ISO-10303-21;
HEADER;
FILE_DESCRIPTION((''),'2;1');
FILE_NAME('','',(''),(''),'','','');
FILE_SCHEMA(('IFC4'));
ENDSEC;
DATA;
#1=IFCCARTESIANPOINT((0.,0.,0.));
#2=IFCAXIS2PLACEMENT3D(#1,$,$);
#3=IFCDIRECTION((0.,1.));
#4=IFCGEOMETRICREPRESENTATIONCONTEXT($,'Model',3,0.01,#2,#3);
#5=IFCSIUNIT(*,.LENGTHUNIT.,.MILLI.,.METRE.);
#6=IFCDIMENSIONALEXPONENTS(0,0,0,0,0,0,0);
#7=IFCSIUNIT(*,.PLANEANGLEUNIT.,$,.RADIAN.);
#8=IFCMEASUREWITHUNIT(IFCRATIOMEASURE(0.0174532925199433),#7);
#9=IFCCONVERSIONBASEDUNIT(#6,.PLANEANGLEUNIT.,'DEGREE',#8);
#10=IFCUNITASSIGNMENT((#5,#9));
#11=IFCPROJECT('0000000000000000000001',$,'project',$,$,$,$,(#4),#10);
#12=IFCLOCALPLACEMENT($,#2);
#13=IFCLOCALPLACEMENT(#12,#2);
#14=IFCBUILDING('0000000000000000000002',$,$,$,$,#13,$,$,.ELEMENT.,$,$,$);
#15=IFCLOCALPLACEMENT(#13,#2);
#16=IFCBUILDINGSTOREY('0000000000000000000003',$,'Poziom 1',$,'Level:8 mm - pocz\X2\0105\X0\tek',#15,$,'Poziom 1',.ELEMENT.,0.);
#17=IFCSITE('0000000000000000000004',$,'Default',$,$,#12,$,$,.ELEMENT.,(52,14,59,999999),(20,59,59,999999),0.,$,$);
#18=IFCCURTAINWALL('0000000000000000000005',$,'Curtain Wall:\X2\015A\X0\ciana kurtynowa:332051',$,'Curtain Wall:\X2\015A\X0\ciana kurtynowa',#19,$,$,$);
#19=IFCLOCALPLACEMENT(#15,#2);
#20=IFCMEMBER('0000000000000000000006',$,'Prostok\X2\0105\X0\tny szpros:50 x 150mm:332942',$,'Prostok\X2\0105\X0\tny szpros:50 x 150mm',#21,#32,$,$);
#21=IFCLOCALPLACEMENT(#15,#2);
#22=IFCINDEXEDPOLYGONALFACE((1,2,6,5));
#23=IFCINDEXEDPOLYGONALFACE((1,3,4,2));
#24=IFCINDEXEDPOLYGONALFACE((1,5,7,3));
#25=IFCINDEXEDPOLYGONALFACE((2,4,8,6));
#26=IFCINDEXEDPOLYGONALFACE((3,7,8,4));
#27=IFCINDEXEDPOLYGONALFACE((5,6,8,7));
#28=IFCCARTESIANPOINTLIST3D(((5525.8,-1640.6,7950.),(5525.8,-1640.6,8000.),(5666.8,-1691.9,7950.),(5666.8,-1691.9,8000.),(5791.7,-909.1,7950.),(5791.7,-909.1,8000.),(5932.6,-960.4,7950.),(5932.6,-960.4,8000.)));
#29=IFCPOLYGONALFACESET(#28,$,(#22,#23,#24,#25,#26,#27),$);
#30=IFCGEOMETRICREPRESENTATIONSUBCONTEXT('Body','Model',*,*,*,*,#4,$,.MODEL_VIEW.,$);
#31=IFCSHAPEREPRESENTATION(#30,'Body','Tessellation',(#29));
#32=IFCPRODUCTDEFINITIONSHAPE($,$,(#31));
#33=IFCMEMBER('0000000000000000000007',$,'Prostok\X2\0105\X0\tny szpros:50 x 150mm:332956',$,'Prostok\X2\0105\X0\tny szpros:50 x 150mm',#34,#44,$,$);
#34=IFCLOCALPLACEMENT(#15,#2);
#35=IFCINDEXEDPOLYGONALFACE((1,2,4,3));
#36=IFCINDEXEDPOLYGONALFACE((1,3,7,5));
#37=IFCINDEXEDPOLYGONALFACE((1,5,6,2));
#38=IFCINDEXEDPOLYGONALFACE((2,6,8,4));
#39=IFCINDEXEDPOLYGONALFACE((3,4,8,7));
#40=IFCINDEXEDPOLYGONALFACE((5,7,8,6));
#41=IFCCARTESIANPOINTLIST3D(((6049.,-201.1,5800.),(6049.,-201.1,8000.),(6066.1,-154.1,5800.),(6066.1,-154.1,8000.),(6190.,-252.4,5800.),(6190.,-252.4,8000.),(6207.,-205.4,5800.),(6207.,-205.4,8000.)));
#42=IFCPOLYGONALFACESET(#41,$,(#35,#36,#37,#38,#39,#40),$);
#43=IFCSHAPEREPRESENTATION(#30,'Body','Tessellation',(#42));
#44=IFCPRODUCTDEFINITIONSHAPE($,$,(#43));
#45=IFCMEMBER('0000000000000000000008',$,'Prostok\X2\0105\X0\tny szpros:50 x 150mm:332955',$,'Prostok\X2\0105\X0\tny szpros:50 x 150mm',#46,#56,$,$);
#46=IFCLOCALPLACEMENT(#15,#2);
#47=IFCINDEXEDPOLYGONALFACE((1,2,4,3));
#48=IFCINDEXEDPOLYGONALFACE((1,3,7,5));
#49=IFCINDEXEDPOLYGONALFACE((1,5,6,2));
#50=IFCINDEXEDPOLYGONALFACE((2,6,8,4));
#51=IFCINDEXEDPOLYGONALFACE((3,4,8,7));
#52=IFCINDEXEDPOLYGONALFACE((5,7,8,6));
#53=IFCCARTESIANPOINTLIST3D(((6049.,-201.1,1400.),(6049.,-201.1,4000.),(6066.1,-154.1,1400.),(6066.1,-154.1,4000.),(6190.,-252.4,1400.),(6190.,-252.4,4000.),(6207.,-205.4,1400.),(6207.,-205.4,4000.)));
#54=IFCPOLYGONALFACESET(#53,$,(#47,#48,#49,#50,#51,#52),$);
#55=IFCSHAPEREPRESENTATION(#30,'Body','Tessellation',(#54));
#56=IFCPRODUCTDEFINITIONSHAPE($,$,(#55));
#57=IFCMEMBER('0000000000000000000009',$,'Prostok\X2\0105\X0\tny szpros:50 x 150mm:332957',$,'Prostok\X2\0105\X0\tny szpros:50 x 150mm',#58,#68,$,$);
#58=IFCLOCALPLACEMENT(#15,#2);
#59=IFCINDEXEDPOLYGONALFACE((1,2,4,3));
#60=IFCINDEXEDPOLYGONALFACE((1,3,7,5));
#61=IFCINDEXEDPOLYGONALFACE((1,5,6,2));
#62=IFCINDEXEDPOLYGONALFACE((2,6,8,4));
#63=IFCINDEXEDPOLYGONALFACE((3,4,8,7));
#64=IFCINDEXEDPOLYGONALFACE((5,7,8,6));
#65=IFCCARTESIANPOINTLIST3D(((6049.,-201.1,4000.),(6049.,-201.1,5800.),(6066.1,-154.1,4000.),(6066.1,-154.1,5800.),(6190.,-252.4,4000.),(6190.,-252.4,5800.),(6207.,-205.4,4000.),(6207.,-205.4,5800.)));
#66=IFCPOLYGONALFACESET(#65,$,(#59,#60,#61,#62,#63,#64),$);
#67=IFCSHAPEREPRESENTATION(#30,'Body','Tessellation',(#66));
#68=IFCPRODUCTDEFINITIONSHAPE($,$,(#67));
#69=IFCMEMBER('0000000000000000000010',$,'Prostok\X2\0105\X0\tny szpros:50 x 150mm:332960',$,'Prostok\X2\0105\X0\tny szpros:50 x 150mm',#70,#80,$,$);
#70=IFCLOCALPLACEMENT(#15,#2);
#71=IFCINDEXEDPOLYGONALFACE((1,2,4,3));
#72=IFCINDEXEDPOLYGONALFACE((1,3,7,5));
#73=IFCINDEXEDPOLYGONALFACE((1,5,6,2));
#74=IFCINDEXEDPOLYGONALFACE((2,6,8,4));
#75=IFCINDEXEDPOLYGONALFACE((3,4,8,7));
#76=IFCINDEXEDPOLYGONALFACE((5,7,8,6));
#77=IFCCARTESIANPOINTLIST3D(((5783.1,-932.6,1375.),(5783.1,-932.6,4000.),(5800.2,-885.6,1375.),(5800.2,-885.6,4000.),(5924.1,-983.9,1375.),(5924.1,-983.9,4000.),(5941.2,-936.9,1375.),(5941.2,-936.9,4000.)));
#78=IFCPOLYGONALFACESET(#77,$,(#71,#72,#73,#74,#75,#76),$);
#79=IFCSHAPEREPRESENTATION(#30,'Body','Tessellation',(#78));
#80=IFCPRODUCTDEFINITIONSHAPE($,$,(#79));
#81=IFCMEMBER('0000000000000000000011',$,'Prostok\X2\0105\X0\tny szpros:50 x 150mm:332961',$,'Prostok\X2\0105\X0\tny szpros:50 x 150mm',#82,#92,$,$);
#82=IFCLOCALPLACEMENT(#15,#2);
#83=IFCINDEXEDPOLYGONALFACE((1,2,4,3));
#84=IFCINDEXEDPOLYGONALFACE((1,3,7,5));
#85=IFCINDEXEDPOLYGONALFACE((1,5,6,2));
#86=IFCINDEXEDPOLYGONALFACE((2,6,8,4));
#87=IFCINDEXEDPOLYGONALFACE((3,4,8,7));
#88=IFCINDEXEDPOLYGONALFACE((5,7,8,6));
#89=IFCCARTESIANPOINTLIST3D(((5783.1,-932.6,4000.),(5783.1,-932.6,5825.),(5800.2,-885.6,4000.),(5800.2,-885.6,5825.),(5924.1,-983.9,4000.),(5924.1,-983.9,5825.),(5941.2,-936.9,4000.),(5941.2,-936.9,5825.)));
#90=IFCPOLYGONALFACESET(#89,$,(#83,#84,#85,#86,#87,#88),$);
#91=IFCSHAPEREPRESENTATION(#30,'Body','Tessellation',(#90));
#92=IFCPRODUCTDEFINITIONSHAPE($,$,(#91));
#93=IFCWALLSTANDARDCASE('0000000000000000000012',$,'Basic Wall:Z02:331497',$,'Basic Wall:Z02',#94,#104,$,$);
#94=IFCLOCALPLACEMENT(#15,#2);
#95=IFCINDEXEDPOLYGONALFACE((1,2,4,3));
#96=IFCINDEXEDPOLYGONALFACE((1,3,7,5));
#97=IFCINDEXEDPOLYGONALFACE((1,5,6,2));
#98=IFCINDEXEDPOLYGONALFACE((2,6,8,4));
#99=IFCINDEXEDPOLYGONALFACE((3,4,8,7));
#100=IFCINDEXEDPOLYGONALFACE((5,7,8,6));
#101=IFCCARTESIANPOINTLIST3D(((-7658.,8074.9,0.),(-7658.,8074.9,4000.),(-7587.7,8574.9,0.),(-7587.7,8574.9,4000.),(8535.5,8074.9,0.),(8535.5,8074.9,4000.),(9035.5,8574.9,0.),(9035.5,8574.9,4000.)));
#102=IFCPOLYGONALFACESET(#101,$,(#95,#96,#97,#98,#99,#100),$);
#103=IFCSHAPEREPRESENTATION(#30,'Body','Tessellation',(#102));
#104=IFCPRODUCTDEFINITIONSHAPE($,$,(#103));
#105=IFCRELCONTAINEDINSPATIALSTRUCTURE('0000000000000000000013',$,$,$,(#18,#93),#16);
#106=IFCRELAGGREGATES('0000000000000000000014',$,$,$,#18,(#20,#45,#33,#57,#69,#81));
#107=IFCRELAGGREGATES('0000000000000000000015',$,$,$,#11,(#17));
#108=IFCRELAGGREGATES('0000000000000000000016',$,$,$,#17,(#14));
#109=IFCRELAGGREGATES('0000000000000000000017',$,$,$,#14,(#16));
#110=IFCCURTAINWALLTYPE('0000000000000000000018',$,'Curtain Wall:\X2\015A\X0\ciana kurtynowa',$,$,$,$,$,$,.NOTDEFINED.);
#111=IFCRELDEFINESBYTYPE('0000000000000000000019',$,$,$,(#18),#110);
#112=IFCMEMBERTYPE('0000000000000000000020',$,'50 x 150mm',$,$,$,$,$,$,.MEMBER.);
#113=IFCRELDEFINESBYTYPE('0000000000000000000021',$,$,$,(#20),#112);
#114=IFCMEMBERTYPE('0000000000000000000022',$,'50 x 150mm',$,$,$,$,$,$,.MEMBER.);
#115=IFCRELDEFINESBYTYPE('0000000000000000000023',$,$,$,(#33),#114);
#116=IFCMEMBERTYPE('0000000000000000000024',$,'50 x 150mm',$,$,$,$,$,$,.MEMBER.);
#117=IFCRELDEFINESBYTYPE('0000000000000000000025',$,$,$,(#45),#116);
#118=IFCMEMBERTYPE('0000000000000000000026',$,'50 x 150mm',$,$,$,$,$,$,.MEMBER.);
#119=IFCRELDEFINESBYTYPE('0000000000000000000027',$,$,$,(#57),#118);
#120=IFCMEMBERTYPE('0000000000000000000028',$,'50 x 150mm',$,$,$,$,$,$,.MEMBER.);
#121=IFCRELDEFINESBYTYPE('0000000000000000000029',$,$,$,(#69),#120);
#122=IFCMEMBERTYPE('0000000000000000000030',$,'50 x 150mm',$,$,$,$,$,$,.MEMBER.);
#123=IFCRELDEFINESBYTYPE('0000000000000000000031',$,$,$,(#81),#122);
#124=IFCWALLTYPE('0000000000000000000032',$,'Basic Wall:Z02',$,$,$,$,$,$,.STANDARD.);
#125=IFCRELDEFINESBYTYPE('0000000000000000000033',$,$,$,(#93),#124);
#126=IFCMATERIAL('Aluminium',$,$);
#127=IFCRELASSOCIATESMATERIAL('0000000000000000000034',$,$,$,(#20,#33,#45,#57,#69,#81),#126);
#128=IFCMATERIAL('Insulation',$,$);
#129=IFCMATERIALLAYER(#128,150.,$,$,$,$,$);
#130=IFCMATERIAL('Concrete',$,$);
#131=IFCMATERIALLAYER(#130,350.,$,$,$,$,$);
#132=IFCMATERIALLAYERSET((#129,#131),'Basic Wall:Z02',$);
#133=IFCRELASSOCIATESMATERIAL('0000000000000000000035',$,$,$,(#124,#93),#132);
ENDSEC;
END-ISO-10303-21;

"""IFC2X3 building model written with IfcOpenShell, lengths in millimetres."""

from ifc_helpers import new_model, entity, si_unit, converted_unit, direction, frame, origin, origin_2d_with_axis, place, context, subcontext, project, spatial, polyline, rectangle, outline, extrude, clip, halfspace, source, transform, mapped, material, layer, layer_set, layer_usage, type_object, type_shapes, element, aggregate, save


model = new_model("IFC2X3")

# Units and contexts
model_context = context("Model", 3, precision=0.01, world=origin(), true_north=direction((0.0, 1.0)))
body_context = subcontext(model_context, "Body", "Model", "MODEL_VIEW")
ifc_project = project(units=[si_unit("LENGTHUNIT", "METRE", prefix="MILLI"), converted_unit("PLANEANGLEUNIT", "DEGREE", entity("IfcRatioMeasure", 0.0174532925199433), si_unit("PLANEANGLEUNIT", "RADIAN"), dimensions=[0, 0, 0, 0, 0, 0, 0])], contexts=[model_context])

# Site, building, storey
site_placement = place(None, origin())
site = spatial("IfcSite", under=ifc_project, at=site_placement, Name="Default", CompositionType="ELEMENT", RefLatitude=(52, 14, 59, 999999), RefLongitude=(20, 59, 59, 999999), RefElevation=0.0)
building_placement = place(site_placement, origin())
building = spatial("IfcBuilding", under=site, at=building_placement, CompositionType="ELEMENT")
storey_placement = place(building_placement, origin())
storey = spatial("IfcBuildingStorey", under=building, at=storey_placement, Name="Poziom 1", ObjectType="Level:8 mm - początek", LongName="Poziom 1", CompositionType="ELEMENT", Elevation=0.0)

# Curtain wall, members
curtain_wall_type = type_object("IfcCurtainWallType", Name="Curtain Wall:Ściana kurtynowa", PredefinedType="NOTDEFINED")
curtain_wall_placement = place(storey_placement, origin())
curtain_wall = element("IfcCurtainWall", 1, at=curtain_wall_placement, inside=storey, type_object=curtain_wall_type, Name="Curtain Wall:Ściana kurtynowa:332051", ObjectType="Curtain Wall:Ściana kurtynowa")
ifc_material_1 = material(Name="Aluminium")
member_type_1 = type_object("IfcMemberType", Name="50 x 150mm", PredefinedType="MEMBER")
shared_shape_1 = source(origin(), body_context, "Body", "SweptSolid", [
    extrude(rectangle(XDim=150.0, YDim=50.0, at=origin_2d_with_axis()), frame((-25.0, 0.0, -778.3), z_axis=(0.0, 0.0, 1.0), x_axis=(0.0, -1.0, 0.0)), (0.0, 0.0, 1.0), 778.3),
])
type_shapes(member_type_1, [shared_shape_1])
member_1_placement = place(storey_placement, frame((5862.1, -934.8, 8000.0), z_axis=(0.341586, 0.939851, 0.0), x_axis=(0.0, 0.0, 1.0)))
member_1 = element("IfcMember", 2, at=member_1_placement, type_object=member_type_1, material=ifc_material_1, Name="Prostokątny szpros:50 x 150mm:332942", ObjectType="Prostokątny szpros:50 x 150mm", context=body_context, shape_type="MappedRepresentation", body=[
    mapped(shared_shape_1, transform((0.0, 0.0, 0.0), scale=1.0)),
])
member_type_2 = type_object("IfcMemberType", Name="50 x 150mm", PredefinedType="MEMBER")
shared_shape_2 = source(origin(), body_context, "Body", "SweptSolid", [
    extrude(rectangle(XDim=150.0, YDim=50.0, at=origin_2d_with_axis()), frame((0.0, 0.0, -2200.0), z_axis=(0.0, 0.0, 1.0), x_axis=(0.0, -1.0, 0.0)), (0.0, 0.0, 1.0), 2200.0),
])
type_shapes(member_type_2, [shared_shape_2])
member_2_placement = place(storey_placement, frame((6128.0, -203.2, 5800.0), z_axis=(0.0, 0.0, -1.0), x_axis=(0.341586, 0.939851, 0.0)))
member_2 = element("IfcMember", 3, at=member_2_placement, type_object=member_type_2, material=ifc_material_1, Name="Prostokątny szpros:50 x 150mm:332956", ObjectType="Prostokątny szpros:50 x 150mm", context=body_context, shape_type="MappedRepresentation", body=[
    mapped(shared_shape_2, transform((0.0, 0.0, 0.0), scale=1.0)),
])
member_type_3 = type_object("IfcMemberType", Name="50 x 150mm", PredefinedType="MEMBER")
shared_shape_3 = source(origin(), body_context, "Body", "SweptSolid", [
    extrude(rectangle(XDim=150.0, YDim=50.0, at=origin_2d_with_axis()), frame((0.0, 0.0, -2600.0), z_axis=(0.0, 0.0, 1.0), x_axis=(0.0, -1.0, 0.0)), (0.0, 0.0, 1.0), 2600.0),
])
type_shapes(member_type_3, [shared_shape_3])
member_3_placement = place(storey_placement, frame((6128.0, -203.2, 1400.0), z_axis=(0.0, 0.0, -1.0), x_axis=(0.341586, 0.939851, 0.0)))
member_3 = element("IfcMember", 4, at=member_3_placement, type_object=member_type_3, material=ifc_material_1, Name="Prostokątny szpros:50 x 150mm:332955", ObjectType="Prostokątny szpros:50 x 150mm", context=body_context, shape_type="MappedRepresentation", body=[
    mapped(shared_shape_3, transform((0.0, 0.0, 0.0), scale=1.0)),
])
member_type_4 = type_object("IfcMemberType", Name="50 x 150mm", PredefinedType="MEMBER")
shared_shape_4 = source(origin(), body_context, "Body", "SweptSolid", [
    extrude(rectangle(XDim=150.0, YDim=50.0, at=origin_2d_with_axis()), frame((0.0, 0.0, -1800.0), z_axis=(0.0, 0.0, 1.0), x_axis=(0.0, -1.0, 0.0)), (0.0, 0.0, 1.0), 1800.0),
])
type_shapes(member_type_4, [shared_shape_4])
member_4_placement = place(storey_placement, frame((6128.0, -203.2, 4000.0), z_axis=(0.0, 0.0, -1.0), x_axis=(0.341586, 0.939851, 0.0)))
member_4 = element("IfcMember", 5, at=member_4_placement, type_object=member_type_4, material=ifc_material_1, Name="Prostokątny szpros:50 x 150mm:332957", ObjectType="Prostokątny szpros:50 x 150mm", context=body_context, shape_type="MappedRepresentation", body=[
    mapped(shared_shape_4, transform((0.0, 0.0, 0.0), scale=1.0)),
])
member_type_5 = type_object("IfcMemberType", Name="50 x 150mm", PredefinedType="MEMBER")
shared_shape_5 = source(origin(), body_context, "Body", "SweptSolid", [
    extrude(rectangle(XDim=150.0, YDim=50.0, at=origin_2d_with_axis()), frame((0.0, 0.0, -2625.0), z_axis=(0.0, 0.0, 1.0), x_axis=(0.0, -1.0, 0.0)), (0.0, 0.0, 1.0), 2625.0),
])
type_shapes(member_type_5, [shared_shape_5])
member_5_placement = place(storey_placement, frame((5862.1, -934.8, 1375.0), z_axis=(0.0, 0.0, -1.0), x_axis=(0.341586, 0.939851, 0.0)))
member_5 = element("IfcMember", 6, at=member_5_placement, type_object=member_type_5, material=ifc_material_1, Name="Prostokątny szpros:50 x 150mm:332960", ObjectType="Prostokątny szpros:50 x 150mm", context=body_context, shape_type="MappedRepresentation", body=[
    mapped(shared_shape_5, transform((0.0, 0.0, 0.0), scale=1.0)),
])
member_type_6 = type_object("IfcMemberType", Name="50 x 150mm", PredefinedType="MEMBER")
shared_shape_6 = source(origin(), body_context, "Body", "SweptSolid", [
    extrude(rectangle(XDim=150.0, YDim=50.0, at=origin_2d_with_axis()), frame((0.0, 0.0, -1825.0), z_axis=(0.0, 0.0, 1.0), x_axis=(0.0, -1.0, 0.0)), (0.0, 0.0, 1.0), 1825.0),
])
type_shapes(member_type_6, [shared_shape_6])
member_6_placement = place(storey_placement, frame((5862.1, -934.8, 4000.0), z_axis=(0.0, 0.0, -1.0), x_axis=(0.341586, 0.939851, 0.0)))
member_6 = element("IfcMember", 7, at=member_6_placement, type_object=member_type_6, material=ifc_material_1, Name="Prostokątny szpros:50 x 150mm:332961", ObjectType="Prostokątny szpros:50 x 150mm", context=body_context, shape_type="MappedRepresentation", body=[
    mapped(shared_shape_6, transform((0.0, 0.0, 0.0), scale=1.0)),
])
aggregate(curtain_wall, [member_1, member_3, member_2, member_4, member_5, member_6])

# Wall
ifc_material_2 = material(Name="Insulation")
ifc_layer_1 = layer(ifc_material_2, 150.0)
ifc_material_3 = material(Name="Concrete")
ifc_layer_2 = layer(ifc_material_3, 350.0)
ifc_layer_set_1 = layer_set([ifc_layer_1, ifc_layer_2], Name="Basic Wall:Z02")
ifc_layer_usage_1 = layer_usage(ifc_layer_set_1, "AXIS2", "NEGATIVE", 250.0)
wall_type = type_object("IfcWallType", Name="Basic Wall:Z02", PredefinedType="STANDARD", material=ifc_layer_set_1)
wall_placement = place(storey_placement, frame((9035.5, 8324.9, 0.0), z_axis=(0.0, 0.0, 1.0), x_axis=(-1.0, 0.0, 0.0)))
element("IfcWallStandardCase", 8, at=wall_placement, inside=storey, type_object=wall_type, material=ifc_layer_usage_1, Name="Basic Wall:Z02:331497", ObjectType="Basic Wall:Z02", context=body_context, shape_type="Clipping", body=[
    clip(extrude(outline(polyline([(16623.2, -250.0), (16693.5, 250.0), (500.0, 250.0), (0.0, -250.0), (16623.2, -250.0)])), origin(), (0.0, 0.0, 1.0), 4000.0), halfspace(origin(), True)),
])

save(model, "model.ifc")
